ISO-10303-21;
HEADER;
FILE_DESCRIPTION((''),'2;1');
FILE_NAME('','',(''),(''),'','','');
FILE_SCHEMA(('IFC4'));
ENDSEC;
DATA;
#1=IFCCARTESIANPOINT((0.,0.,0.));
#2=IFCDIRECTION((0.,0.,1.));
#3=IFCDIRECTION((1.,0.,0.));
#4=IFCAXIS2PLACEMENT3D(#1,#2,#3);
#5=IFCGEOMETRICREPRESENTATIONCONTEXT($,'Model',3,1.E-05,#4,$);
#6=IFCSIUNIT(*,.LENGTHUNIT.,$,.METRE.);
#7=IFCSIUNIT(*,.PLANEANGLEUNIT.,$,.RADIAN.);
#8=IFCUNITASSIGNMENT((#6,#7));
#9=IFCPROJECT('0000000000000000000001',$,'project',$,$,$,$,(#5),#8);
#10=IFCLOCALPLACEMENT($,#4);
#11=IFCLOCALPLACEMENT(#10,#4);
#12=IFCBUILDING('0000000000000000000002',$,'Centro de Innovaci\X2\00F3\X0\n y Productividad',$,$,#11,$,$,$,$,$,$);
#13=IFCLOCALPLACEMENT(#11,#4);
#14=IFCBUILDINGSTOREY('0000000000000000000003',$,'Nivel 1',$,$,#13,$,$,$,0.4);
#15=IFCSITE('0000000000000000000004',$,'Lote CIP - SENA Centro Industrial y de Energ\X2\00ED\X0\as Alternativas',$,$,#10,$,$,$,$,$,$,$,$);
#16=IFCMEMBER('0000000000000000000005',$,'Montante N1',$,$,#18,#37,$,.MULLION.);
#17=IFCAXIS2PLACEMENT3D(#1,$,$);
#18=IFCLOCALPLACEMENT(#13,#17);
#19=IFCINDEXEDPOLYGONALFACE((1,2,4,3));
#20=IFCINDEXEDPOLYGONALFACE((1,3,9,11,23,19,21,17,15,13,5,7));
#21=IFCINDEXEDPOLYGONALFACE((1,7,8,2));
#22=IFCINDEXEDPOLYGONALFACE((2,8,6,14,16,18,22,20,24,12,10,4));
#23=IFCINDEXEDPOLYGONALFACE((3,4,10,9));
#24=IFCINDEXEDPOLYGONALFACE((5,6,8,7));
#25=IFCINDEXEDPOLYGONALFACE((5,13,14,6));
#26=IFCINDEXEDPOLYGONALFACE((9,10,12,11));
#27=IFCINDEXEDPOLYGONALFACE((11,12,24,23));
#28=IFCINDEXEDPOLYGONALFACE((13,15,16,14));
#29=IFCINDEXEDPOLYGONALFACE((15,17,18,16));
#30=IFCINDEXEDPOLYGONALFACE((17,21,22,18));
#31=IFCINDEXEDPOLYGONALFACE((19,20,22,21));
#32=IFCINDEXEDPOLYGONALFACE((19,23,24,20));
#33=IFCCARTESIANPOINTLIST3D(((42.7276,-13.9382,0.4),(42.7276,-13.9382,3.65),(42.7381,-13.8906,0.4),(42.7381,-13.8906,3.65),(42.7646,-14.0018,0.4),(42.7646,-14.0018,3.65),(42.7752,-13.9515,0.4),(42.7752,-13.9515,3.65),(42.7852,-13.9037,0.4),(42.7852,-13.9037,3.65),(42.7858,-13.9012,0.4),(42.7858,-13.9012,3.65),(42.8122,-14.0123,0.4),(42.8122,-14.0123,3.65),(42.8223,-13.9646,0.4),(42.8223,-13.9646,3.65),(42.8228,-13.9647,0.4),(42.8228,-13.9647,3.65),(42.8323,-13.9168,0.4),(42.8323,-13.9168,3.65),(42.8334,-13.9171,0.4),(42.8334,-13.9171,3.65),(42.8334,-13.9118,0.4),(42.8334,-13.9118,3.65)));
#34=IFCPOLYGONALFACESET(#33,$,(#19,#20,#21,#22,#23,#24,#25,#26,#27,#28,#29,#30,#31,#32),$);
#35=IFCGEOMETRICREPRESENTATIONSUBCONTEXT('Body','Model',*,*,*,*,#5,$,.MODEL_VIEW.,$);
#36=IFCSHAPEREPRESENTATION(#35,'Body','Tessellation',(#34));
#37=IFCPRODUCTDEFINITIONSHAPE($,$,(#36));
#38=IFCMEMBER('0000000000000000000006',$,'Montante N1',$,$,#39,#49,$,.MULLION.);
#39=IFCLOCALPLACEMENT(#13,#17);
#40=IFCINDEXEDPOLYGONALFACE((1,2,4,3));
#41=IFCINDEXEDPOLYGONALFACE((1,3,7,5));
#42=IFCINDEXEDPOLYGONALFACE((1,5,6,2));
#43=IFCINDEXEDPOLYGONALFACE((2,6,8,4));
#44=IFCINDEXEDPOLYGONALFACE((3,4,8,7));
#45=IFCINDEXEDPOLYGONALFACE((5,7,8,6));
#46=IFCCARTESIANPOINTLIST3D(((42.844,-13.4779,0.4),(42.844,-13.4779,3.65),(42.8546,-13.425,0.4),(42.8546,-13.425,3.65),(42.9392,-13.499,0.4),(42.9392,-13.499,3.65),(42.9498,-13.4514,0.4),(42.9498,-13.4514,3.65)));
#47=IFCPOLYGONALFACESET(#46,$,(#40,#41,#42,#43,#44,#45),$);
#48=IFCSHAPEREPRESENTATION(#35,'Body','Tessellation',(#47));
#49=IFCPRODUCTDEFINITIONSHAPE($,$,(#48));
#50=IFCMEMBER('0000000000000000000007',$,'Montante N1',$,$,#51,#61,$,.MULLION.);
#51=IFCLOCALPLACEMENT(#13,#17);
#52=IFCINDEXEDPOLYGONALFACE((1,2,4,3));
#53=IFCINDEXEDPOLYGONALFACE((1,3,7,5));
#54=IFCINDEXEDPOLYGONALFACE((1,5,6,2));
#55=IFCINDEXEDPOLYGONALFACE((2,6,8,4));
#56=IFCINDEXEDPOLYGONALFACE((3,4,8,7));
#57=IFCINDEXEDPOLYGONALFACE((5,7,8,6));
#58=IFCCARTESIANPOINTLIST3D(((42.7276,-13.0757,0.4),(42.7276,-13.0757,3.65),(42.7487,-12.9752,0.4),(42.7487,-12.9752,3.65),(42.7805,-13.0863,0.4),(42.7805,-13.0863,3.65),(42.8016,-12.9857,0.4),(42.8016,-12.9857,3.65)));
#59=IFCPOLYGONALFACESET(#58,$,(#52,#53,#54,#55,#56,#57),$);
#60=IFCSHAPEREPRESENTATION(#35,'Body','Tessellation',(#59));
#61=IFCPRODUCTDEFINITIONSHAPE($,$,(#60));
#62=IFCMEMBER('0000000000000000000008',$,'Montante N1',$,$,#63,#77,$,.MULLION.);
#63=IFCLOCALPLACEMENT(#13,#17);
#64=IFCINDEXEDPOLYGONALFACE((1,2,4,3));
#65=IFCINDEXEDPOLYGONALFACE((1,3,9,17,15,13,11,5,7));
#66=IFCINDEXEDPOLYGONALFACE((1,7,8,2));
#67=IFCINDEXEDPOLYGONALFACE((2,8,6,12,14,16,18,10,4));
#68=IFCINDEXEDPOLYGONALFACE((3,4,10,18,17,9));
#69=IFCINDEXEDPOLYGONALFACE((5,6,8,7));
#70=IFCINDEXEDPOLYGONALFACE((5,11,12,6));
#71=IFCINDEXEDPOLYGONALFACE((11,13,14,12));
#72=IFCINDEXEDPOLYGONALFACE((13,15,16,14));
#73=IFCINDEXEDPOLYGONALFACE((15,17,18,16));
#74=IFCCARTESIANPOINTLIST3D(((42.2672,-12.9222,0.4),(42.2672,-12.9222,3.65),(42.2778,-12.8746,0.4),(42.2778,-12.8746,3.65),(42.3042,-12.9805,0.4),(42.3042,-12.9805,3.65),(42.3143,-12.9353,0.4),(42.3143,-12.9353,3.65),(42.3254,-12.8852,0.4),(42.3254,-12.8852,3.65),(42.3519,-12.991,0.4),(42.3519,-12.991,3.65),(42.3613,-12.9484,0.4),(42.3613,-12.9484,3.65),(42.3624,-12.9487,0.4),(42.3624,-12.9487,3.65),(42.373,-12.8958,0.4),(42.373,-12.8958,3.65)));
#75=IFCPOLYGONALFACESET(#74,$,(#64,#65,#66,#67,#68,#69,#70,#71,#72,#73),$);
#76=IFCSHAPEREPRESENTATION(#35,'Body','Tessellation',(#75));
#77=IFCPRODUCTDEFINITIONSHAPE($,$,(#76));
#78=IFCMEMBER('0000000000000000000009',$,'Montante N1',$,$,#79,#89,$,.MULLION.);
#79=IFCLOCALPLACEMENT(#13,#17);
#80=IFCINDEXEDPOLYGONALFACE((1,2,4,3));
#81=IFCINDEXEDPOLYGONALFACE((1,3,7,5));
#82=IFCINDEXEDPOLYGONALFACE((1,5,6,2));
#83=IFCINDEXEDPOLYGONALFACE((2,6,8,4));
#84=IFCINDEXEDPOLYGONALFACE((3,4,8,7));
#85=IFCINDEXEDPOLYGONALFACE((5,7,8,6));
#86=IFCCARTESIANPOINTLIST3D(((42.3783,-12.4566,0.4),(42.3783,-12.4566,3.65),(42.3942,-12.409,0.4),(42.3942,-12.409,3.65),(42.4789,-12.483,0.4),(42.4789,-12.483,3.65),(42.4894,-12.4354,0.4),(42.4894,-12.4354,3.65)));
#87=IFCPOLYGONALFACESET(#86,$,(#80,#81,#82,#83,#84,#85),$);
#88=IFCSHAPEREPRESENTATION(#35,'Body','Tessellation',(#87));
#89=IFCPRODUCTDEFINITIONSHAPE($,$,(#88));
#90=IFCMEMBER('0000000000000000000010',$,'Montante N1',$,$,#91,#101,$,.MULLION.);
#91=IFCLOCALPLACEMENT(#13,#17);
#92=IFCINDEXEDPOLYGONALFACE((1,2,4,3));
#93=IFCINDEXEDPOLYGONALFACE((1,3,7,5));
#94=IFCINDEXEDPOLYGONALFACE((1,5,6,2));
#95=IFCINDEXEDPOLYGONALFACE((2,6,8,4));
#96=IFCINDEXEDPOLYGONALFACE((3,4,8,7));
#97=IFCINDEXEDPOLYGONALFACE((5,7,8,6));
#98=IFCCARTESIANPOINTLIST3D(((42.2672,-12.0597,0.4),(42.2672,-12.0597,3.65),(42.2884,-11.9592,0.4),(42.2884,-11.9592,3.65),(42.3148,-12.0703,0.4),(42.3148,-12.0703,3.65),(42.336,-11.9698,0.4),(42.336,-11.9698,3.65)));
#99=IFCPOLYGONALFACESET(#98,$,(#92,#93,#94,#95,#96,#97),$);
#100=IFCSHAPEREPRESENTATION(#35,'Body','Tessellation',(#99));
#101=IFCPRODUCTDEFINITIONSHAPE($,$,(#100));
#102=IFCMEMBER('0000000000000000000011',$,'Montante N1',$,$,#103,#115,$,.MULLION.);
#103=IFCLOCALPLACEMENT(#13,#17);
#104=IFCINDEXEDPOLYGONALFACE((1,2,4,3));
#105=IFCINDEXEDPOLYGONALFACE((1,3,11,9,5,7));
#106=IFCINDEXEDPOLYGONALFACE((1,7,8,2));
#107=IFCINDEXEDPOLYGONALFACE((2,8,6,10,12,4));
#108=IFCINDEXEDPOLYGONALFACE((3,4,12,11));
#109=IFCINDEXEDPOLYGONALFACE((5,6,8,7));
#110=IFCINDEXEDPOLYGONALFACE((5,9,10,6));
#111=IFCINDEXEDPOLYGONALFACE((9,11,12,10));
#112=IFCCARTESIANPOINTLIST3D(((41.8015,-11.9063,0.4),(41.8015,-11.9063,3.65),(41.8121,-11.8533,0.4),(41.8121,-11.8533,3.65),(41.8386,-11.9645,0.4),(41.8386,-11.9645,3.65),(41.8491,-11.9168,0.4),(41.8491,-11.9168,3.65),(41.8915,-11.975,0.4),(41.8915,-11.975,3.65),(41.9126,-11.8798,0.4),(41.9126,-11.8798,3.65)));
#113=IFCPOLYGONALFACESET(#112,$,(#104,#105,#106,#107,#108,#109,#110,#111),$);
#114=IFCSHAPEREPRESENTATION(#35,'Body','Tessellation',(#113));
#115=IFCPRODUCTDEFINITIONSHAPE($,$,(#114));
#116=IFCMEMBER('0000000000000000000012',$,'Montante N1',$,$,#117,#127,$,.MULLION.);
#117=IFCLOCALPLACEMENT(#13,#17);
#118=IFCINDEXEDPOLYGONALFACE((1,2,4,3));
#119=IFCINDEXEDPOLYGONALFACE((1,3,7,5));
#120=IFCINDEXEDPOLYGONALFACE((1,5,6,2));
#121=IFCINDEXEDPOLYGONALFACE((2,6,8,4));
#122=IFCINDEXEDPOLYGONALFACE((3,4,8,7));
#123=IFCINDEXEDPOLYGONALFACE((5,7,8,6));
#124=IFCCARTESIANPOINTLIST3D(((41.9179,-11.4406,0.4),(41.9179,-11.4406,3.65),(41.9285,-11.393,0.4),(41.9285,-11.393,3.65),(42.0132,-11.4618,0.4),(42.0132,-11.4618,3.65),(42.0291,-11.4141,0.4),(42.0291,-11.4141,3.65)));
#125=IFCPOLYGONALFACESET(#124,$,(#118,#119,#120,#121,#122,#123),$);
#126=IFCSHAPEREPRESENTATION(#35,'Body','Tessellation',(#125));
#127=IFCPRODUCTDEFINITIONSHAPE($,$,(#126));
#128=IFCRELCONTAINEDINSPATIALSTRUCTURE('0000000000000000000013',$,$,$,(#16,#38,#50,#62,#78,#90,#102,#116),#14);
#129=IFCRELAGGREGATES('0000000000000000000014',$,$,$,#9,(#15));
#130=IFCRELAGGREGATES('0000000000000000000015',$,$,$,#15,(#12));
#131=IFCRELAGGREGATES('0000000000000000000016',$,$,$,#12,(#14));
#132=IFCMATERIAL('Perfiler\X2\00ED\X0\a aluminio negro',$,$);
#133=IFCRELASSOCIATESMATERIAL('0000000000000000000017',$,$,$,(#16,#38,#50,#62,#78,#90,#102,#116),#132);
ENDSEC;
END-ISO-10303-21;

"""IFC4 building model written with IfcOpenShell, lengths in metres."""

from ifc_helpers import new_model, si_unit, frame, origin_with_axes, place, context, subcontext, project, spatial, polyline, outline, extrude, material, element, save


model = new_model("IFC4")

# Units and contexts
model_context = context("Model", 3, precision=1e-05, world=origin_with_axes())
body_context = subcontext(model_context, "Body", "Model", "MODEL_VIEW")
ifc_project = project(units=[si_unit("LENGTHUNIT", "METRE"), si_unit("PLANEANGLEUNIT", "RADIAN")], contexts=[model_context])

# Site, building, storey
site_placement = place(None, origin_with_axes())
site = spatial("IfcSite", under=ifc_project, at=site_placement, Name="Lote CIP - SENA Centro Industrial y de Energías Alternativas")
building_placement = place(site_placement, origin_with_axes())
building = spatial("IfcBuilding", under=site, at=building_placement, Name="Centro de Innovación y Productividad")
storey_placement = place(building_placement, origin_with_axes())
storey = spatial("IfcBuildingStorey", under=building, at=storey_placement, Name="Nivel 1", Elevation=0.4)

# Members
ifc_material = material(Name="Perfilería aluminio negro")
member_1_placement = place(storey_placement, origin_with_axes())
element("IfcMember", 1, at=member_1_placement, inside=storey, material=ifc_material, Name="Montante N1", PredefinedType="MULLION", context=body_context, shape_type="SweptSolid", body=[
    extrude(outline(polyline([(42.8334, -13.9171), (42.8228, -13.9647), (42.8223, -13.9646), (42.8122, -14.0123), (42.7646, -14.0018), (42.7752, -13.9515), (42.7276, -13.9382), (42.7381, -13.8906), (42.7852, -13.9037), (42.7858, -13.9012), (42.8334, -13.9118), (42.8323, -13.9168), (42.8334, -13.9171)])), frame((0.0, 0.0, 0.4)), (0.0, 0.0, 1.0), 3.25),
])
member_2_placement = place(storey_placement, origin_with_axes())
element("IfcMember", 2, at=member_2_placement, inside=storey, material=ifc_material, Name="Montante N1", PredefinedType="MULLION", context=body_context, shape_type="SweptSolid", body=[
    extrude(outline(polyline([(42.844, -13.4779), (42.8546, -13.425), (42.9498, -13.4514), (42.9392, -13.499), (42.844, -13.4779)])), frame((0.0, 0.0, 0.4)), (0.0, 0.0, 1.0), 3.25),
])
member_3_placement = place(storey_placement, origin_with_axes())
element("IfcMember", 3, at=member_3_placement, inside=storey, material=ifc_material, Name="Montante N1", PredefinedType="MULLION", context=body_context, shape_type="SweptSolid", body=[
    extrude(outline(polyline([(42.7487, -12.9752), (42.8016, -12.9857), (42.7805, -13.0863), (42.7276, -13.0757), (42.7487, -12.9752)])), frame((0.0, 0.0, 0.4)), (0.0, 0.0, 1.0), 3.25),
])
member_4_placement = place(storey_placement, origin_with_axes())
element("IfcMember", 4, at=member_4_placement, inside=storey, material=ifc_material, Name="Montante N1", PredefinedType="MULLION", context=body_context, shape_type="SweptSolid", body=[
    extrude(outline(polyline([(42.3519, -12.991), (42.3042, -12.9805), (42.3143, -12.9353), (42.2672, -12.9223), (42.2778, -12.8746), (42.3254, -12.8852), (42.373, -12.8958), (42.3624, -12.9487), (42.3613, -12.9484), (42.3519, -12.991)])), frame((0.0, 0.0, 0.4)), (0.0, 0.0, 1.0), 3.25),
])
member_5_placement = place(storey_placement, origin_with_axes())
element("IfcMember", 5, at=member_5_placement, inside=storey, material=ifc_material, Name="Montante N1", PredefinedType="MULLION", context=body_context, shape_type="SweptSolid", body=[
    extrude(outline(polyline([(42.3942, -12.409), (42.4894, -12.4354), (42.4789, -12.483), (42.3783, -12.4566), (42.3942, -12.409)])), frame((0.0, 0.0, 0.4)), (0.0, 0.0, 1.0), 3.25),
])
member_6_placement = place(storey_placement, origin_with_axes())
element("IfcMember", 6, at=member_6_placement, inside=storey, material=ifc_material, Name="Montante N1", PredefinedType="MULLION", context=body_context, shape_type="SweptSolid", body=[
    extrude(outline(polyline([(42.2884, -11.9592), (42.336, -11.9697), (42.3148, -12.0703), (42.2672, -12.0597), (42.2884, -11.9592)])), frame((0.0, 0.0, 0.4)), (0.0, 0.0, 1.0), 3.25),
])
member_7_placement = place(storey_placement, origin_with_axes())
element("IfcMember", 7, at=member_7_placement, inside=storey, material=ifc_material, Name="Montante N1", PredefinedType="MULLION", context=body_context, shape_type="SweptSolid", body=[
    extrude(outline(polyline([(41.8015, -11.9063), (41.8121, -11.8533), (41.9126, -11.8798), (41.8915, -11.975), (41.8386, -11.9645), (41.8491, -11.9168), (41.8015, -11.9063)])), frame((0.0, 0.0, 0.4)), (0.0, 0.0, 1.0), 3.25),
])
member_8_placement = place(storey_placement, origin_with_axes())
element("IfcMember", 8, at=member_8_placement, inside=storey, material=ifc_material, Name="Montante N1", PredefinedType="MULLION", context=body_context, shape_type="SweptSolid", body=[
    extrude(outline(polyline([(41.9285, -11.393), (42.0291, -11.4141), (42.0132, -11.4618), (41.9179, -11.4406), (41.9285, -11.393)])), frame((0.0, 0.0, 0.4)), (0.0, 0.0, 1.0), 3.25),
])

save(model, "model.ifc")
